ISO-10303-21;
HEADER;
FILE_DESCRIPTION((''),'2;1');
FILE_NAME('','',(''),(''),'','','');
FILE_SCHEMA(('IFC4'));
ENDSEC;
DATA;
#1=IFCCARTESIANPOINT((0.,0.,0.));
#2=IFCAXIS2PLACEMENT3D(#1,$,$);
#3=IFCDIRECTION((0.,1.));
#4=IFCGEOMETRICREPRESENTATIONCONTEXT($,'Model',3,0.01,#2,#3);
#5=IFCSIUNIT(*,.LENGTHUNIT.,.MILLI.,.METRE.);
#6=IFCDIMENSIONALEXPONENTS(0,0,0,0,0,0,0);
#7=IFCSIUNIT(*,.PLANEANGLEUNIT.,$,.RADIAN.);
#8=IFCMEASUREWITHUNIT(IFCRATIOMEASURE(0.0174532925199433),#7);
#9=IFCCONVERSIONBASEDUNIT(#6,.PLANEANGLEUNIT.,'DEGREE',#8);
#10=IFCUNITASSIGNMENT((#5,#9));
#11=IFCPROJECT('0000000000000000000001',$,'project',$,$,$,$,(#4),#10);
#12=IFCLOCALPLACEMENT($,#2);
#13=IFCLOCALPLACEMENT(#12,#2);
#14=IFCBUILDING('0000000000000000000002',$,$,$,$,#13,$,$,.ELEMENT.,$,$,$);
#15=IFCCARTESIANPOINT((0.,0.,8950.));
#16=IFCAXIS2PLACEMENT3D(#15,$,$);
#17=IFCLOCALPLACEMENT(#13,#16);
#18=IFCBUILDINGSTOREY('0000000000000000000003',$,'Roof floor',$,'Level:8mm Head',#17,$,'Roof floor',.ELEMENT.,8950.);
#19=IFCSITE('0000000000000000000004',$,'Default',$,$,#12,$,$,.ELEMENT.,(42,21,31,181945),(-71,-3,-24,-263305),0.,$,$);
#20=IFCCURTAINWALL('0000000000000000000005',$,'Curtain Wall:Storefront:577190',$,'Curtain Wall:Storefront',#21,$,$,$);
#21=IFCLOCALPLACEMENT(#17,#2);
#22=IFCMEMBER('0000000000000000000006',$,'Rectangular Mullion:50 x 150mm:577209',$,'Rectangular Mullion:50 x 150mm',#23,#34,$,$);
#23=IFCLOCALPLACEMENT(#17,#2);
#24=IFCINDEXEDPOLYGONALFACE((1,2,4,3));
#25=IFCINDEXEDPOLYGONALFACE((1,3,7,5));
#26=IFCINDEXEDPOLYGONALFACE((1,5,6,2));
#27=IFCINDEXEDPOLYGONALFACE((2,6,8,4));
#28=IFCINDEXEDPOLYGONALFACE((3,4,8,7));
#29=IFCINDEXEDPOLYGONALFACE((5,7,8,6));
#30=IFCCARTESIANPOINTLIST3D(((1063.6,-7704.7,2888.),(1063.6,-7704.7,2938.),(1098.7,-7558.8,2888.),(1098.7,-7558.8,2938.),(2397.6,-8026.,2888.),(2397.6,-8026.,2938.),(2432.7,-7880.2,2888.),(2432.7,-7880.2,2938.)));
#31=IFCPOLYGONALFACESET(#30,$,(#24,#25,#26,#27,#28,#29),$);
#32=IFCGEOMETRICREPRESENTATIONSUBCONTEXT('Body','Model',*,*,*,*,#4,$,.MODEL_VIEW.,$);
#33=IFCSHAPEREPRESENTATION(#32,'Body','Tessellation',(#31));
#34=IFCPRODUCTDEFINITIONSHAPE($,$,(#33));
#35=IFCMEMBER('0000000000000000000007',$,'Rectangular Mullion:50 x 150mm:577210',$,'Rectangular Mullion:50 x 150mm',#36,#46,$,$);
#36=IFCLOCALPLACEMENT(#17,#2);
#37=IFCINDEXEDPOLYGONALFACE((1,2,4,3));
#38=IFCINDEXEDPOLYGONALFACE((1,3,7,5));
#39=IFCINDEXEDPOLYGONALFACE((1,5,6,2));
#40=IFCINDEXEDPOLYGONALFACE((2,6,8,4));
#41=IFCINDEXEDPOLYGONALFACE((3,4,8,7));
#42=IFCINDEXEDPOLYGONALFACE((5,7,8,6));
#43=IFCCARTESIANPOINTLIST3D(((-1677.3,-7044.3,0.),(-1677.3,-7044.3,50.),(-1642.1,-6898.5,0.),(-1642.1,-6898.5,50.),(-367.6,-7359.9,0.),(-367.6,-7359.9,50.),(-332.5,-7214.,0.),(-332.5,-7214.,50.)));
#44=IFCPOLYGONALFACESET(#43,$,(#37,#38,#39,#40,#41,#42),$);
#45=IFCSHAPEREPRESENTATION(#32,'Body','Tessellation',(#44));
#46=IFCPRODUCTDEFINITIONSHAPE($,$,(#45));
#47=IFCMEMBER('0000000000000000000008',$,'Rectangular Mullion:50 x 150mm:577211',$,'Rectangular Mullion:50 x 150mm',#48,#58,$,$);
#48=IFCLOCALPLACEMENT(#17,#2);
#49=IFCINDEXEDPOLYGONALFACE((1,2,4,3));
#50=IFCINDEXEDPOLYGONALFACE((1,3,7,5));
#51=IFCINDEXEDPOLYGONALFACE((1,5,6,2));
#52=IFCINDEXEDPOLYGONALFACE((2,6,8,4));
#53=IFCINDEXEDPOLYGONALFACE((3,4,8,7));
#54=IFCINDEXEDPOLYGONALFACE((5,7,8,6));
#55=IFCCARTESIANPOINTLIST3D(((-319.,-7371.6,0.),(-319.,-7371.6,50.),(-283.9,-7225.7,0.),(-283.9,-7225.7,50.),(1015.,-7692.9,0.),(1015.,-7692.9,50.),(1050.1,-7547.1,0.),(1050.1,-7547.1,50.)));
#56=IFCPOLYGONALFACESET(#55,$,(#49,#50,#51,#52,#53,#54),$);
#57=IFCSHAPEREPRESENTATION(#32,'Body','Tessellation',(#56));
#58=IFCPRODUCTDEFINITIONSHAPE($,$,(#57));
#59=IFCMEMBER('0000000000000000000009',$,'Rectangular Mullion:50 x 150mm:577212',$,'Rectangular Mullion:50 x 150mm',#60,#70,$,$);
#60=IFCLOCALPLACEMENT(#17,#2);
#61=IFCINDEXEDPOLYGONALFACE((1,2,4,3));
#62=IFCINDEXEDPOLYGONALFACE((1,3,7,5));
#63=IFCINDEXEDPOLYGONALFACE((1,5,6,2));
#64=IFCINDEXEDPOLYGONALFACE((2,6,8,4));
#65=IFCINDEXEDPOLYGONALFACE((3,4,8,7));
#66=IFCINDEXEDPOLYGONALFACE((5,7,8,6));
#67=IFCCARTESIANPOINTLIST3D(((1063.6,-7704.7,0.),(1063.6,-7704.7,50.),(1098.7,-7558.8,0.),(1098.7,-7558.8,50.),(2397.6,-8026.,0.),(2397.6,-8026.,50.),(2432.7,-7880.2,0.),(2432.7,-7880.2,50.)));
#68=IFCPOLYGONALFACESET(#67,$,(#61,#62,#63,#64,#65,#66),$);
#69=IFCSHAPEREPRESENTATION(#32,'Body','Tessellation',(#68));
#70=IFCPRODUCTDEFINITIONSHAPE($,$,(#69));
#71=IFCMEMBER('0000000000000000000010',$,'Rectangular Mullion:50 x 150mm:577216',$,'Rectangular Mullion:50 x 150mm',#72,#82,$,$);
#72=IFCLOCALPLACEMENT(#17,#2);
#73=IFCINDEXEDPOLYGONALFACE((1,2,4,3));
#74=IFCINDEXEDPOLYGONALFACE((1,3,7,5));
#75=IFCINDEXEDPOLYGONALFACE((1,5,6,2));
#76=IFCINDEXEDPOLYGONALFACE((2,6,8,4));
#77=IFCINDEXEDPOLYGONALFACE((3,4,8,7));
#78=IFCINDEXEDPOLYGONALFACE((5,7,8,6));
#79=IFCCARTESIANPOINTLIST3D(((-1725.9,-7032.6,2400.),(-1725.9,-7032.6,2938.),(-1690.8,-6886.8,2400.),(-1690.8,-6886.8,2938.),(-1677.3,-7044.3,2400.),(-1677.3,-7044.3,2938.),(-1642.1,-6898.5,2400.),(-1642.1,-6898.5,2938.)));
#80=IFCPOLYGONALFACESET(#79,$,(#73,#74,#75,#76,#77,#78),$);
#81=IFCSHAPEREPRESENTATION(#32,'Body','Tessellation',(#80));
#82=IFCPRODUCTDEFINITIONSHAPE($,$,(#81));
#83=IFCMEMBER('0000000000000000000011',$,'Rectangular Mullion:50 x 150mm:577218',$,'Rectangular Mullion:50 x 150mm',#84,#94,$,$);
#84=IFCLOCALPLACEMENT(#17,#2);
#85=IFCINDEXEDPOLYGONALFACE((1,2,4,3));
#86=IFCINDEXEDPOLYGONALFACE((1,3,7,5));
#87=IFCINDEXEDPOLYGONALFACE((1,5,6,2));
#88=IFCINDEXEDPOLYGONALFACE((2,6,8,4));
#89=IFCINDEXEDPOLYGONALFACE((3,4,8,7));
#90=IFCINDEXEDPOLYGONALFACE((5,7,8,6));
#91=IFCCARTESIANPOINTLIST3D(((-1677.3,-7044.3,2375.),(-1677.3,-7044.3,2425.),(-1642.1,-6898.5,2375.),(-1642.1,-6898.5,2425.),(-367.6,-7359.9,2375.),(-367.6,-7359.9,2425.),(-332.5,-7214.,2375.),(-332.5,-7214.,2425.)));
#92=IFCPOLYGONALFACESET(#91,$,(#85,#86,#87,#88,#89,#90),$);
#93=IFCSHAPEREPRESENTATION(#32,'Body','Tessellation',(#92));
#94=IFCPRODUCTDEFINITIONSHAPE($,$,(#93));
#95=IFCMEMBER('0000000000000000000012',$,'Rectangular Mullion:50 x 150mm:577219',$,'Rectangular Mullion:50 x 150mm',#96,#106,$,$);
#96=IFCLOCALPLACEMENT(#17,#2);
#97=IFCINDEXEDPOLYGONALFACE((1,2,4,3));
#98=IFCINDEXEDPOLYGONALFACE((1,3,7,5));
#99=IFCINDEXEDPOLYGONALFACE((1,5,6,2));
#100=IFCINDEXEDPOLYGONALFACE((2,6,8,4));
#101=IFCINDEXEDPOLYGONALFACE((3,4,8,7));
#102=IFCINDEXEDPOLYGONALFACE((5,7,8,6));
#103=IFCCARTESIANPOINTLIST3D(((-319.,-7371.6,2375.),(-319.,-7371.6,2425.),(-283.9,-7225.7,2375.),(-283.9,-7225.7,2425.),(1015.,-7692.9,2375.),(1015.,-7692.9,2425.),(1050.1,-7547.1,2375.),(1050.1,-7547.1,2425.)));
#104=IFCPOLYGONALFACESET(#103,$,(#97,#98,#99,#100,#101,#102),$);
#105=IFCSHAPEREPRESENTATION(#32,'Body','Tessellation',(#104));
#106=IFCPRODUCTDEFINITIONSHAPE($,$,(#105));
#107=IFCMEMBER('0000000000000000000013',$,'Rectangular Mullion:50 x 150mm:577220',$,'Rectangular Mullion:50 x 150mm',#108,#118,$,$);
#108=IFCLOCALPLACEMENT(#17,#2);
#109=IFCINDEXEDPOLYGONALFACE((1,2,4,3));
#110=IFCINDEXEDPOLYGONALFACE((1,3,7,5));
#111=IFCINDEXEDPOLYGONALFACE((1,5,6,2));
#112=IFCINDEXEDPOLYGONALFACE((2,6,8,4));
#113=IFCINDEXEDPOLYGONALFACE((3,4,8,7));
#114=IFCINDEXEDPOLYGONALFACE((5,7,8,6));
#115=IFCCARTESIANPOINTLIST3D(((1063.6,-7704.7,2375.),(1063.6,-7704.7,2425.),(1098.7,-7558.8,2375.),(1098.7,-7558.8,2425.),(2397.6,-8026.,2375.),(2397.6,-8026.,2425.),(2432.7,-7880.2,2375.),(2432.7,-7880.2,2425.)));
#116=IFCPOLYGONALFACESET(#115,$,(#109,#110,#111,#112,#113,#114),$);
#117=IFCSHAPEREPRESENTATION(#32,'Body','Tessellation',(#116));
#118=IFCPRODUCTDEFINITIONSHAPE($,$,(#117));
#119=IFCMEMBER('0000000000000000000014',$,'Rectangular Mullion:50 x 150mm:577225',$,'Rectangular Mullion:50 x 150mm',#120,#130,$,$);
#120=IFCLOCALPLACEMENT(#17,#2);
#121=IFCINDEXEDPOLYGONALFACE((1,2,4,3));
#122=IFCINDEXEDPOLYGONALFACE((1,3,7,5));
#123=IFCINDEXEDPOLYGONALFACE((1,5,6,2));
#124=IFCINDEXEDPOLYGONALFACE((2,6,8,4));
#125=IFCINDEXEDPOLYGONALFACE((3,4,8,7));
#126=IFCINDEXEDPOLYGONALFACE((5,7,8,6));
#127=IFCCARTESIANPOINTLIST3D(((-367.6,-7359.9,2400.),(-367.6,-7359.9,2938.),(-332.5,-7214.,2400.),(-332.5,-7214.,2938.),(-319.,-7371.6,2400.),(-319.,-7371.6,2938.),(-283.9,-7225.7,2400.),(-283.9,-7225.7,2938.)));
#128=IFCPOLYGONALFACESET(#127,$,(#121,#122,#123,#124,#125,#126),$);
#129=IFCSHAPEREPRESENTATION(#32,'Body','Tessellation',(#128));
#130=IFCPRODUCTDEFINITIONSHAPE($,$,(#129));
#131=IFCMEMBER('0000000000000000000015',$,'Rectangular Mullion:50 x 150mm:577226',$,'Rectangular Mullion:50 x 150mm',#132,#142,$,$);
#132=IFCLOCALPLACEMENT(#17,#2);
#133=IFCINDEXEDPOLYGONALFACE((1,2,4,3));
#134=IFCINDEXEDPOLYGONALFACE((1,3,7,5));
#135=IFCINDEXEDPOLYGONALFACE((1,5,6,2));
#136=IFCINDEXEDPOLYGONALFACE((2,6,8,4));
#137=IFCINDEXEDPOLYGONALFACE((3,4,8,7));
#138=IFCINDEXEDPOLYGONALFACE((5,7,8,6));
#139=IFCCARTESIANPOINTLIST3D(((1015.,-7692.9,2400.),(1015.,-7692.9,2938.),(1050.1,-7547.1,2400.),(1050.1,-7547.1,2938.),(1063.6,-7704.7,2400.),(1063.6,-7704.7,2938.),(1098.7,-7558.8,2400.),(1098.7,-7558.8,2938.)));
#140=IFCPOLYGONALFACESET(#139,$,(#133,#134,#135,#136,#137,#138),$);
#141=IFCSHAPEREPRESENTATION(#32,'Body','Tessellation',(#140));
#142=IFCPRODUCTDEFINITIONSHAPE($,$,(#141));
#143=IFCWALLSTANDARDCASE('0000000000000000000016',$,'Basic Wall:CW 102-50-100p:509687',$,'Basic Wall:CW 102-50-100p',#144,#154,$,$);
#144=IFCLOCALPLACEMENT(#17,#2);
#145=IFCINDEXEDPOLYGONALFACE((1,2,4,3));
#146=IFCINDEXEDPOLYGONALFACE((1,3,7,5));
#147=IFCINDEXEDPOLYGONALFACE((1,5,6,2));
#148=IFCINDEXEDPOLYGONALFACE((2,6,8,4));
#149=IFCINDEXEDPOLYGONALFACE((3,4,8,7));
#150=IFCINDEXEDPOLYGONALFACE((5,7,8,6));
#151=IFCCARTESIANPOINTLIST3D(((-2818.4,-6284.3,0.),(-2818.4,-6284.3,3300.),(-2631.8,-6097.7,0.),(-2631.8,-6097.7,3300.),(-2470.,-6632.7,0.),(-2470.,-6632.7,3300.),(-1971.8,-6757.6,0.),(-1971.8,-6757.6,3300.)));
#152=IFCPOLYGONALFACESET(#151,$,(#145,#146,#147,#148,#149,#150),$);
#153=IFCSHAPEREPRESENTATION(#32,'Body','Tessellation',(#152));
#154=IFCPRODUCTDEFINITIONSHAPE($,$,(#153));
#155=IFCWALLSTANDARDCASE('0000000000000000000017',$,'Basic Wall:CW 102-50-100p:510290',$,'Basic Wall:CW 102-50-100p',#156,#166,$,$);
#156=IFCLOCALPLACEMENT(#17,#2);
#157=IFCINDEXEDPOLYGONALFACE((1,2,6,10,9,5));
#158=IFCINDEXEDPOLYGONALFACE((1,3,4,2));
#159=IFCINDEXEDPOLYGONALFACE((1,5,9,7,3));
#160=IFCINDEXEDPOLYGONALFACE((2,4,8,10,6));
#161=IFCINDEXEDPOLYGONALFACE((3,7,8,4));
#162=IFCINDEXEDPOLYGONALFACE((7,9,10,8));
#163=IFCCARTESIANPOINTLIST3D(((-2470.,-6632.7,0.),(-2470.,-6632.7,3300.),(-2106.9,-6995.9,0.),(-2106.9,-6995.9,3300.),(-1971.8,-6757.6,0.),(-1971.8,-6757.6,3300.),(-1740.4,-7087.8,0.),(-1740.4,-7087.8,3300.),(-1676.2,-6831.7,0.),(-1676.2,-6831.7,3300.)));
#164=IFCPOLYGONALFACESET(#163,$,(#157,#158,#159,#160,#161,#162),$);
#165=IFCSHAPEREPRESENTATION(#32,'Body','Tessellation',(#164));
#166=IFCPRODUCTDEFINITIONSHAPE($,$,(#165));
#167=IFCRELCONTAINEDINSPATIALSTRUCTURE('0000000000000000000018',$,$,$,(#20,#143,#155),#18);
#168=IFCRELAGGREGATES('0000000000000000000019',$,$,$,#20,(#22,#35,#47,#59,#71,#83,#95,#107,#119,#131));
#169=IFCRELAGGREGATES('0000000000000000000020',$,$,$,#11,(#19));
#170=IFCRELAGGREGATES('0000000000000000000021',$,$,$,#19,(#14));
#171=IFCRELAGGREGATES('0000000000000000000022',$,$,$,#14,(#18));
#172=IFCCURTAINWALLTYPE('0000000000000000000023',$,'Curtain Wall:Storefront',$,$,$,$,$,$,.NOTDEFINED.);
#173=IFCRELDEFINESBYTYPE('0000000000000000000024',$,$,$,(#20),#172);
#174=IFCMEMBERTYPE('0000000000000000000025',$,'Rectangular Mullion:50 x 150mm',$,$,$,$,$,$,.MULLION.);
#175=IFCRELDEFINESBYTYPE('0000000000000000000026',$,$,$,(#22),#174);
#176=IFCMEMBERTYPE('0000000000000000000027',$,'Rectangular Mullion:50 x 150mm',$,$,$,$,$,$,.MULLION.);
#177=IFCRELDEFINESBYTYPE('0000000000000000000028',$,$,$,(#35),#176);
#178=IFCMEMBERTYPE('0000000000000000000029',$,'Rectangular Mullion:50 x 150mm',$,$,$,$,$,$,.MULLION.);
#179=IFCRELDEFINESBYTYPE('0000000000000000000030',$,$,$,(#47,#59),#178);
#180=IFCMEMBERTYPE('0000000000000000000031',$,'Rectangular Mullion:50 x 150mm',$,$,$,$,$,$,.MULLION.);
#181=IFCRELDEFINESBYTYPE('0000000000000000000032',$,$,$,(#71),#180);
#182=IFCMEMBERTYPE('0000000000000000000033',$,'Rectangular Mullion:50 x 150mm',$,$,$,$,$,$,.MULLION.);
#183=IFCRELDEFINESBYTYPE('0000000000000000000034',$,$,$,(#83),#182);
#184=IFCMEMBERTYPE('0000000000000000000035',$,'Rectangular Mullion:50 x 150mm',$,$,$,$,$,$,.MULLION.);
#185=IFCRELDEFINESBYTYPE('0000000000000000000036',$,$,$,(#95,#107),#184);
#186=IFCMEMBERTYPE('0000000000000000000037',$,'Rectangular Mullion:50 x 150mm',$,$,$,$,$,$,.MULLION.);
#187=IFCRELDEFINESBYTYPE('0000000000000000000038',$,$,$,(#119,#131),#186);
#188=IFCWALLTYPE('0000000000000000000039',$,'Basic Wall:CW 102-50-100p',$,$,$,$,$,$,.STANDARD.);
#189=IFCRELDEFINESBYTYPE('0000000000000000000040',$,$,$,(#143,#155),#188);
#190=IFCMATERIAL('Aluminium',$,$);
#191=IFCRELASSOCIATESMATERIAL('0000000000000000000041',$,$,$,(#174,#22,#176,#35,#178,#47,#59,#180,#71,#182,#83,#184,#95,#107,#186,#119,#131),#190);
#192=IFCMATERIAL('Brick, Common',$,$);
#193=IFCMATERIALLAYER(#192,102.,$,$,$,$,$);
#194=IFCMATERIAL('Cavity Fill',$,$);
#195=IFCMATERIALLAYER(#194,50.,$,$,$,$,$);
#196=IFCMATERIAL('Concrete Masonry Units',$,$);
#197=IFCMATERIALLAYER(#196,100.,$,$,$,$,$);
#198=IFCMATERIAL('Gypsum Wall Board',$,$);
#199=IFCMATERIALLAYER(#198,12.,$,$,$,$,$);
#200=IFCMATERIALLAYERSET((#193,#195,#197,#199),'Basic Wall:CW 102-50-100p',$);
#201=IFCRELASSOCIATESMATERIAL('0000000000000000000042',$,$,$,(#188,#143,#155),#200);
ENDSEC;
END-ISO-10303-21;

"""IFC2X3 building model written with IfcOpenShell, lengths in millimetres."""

from ifc_helpers import new_model, entity, si_unit, converted_unit, direction, frame, origin, origin_2d_with_axis, place, context, subcontext, project, spatial, polyline, rectangle, outline, extrude, source, transform, mapped, material, layer, layer_set, layer_usage, type_object, type_shapes, element, aggregate, save


model = new_model("IFC2X3")

# Units and contexts
model_context = context("Model", 3, precision=0.01, world=origin(), true_north=direction((0.0, 1.0)))
body_context = subcontext(model_context, "Body", "Model", "MODEL_VIEW")
ifc_project = project(units=[si_unit("LENGTHUNIT", "METRE", prefix="MILLI"), converted_unit("PLANEANGLEUNIT", "DEGREE", entity("IfcRatioMeasure", 0.0174532925199433), si_unit("PLANEANGLEUNIT", "RADIAN"), dimensions=[0, 0, 0, 0, 0, 0, 0])], contexts=[model_context])

# Site, building, storey
site_placement = place(None, origin())
site = spatial("IfcSite", under=ifc_project, at=site_placement, Name="Default", CompositionType="ELEMENT", RefLatitude=(42, 21, 31, 181945), RefLongitude=(-71, -3, -24, -263305), RefElevation=0.0)
building_placement = place(site_placement, origin())
building = spatial("IfcBuilding", under=site, at=building_placement, CompositionType="ELEMENT")
storey_placement = place(building_placement, frame((0.0, 0.0, 8950.0)))
storey = spatial("IfcBuildingStorey", under=building, at=storey_placement, Name="Roof floor", ObjectType="Level:8mm Head", LongName="Roof floor", CompositionType="ELEMENT", Elevation=8950.0)

# Curtain wall
curtain_wall_type = type_object("IfcCurtainWallType", Name="Curtain Wall:Storefront", PredefinedType="NOTDEFINED")
ifc_material_1 = material(Name="Aluminium")
curtain_wall_1_placement = place(storey_placement, frame((0.0, 0.0, -8950.0)))
curtain_wall_1 = element("IfcCurtainWall", 1, at=curtain_wall_1_placement, inside=storey, type_object=curtain_wall_type, Name="Curtain Wall:Storefront:577190", ObjectType="Curtain Wall:Storefront")

# Members
member_type_1 = type_object("IfcMemberType", Name="Rectangular Mullion:50 x 150mm", PredefinedType="MULLION", material=ifc_material_1)
shared_shape_1 = source(origin(), body_context, "Body", "SweptSolid", [
    extrude(rectangle(XDim=150.0, YDim=50.0, at=origin_2d_with_axis()), frame((-25.0, 0.0, -1372.1), z_axis=(0.0, 0.0, 1.0), x_axis=(0.0, -1.0, 0.0)), (0.0, 0.0, 1.0), 1372.1),
])
type_shapes(member_type_1, [shared_shape_1])
member_1_placement = place(storey_placement, frame((2415.1, -7953.1, 2938.0), z_axis=(0.972184, -0.234217, 0.0), x_axis=(0.0, 0.0, 1.0)))
member_1 = element("IfcMember", 2, at=member_1_placement, type_object=member_type_1, material=ifc_material_1, Name="Rectangular Mullion:50 x 150mm:577209", ObjectType="Rectangular Mullion:50 x 150mm", context=body_context, shape_type="MappedRepresentation", body=[
    mapped(shared_shape_1, transform((0.0, 0.0, 0.0), scale=1.0)),
])
member_type_2 = type_object("IfcMemberType", Name="Rectangular Mullion:50 x 150mm", PredefinedType="MULLION", material=ifc_material_1)
shared_shape_2 = source(origin(), body_context, "Body", "SweptSolid", [
    extrude(rectangle(XDim=150.0, YDim=50.0, at=origin_2d_with_axis()), frame((-25.0, 0.0, -1347.1), z_axis=(0.0, 0.0, 1.0), x_axis=(0.0, -1.0, 0.0)), (0.0, 0.0, 1.0), 1347.1),
])
type_shapes(member_type_2, [shared_shape_2])
member_2_placement = place(storey_placement, frame((-1659.7, -6971.4, 0.0), z_axis=(-0.972184, 0.234217, 0.0), x_axis=(0.0, 0.0, -1.0)))
member_2 = element("IfcMember", 3, at=member_2_placement, type_object=member_type_2, material=ifc_material_1, Name="Rectangular Mullion:50 x 150mm:577210", ObjectType="Rectangular Mullion:50 x 150mm", context=body_context, shape_type="MappedRepresentation", body=[
    mapped(shared_shape_2, transform((0.0, 0.0, 0.0), scale=1.0)),
])
member_type_3 = type_object("IfcMemberType", Name="Rectangular Mullion:50 x 150mm", PredefinedType="MULLION", material=ifc_material_1)
shared_shape_3 = source(origin(), body_context, "Body", "SweptSolid", [
    extrude(rectangle(XDim=150.0, YDim=50.0, at=origin_2d_with_axis()), frame((-25.0, 0.0, -1372.1), z_axis=(0.0, 0.0, 1.0), x_axis=(0.0, -1.0, 0.0)), (0.0, 0.0, 1.0), 1372.1),
])
type_shapes(member_type_3, [shared_shape_3])
member_3_placement = place(storey_placement, frame((-301.4, -7298.7, 0.0), z_axis=(-0.972184, 0.234217, 0.0), x_axis=(0.0, 0.0, -1.0)))
member_3 = element("IfcMember", 4, at=member_3_placement, type_object=member_type_3, material=ifc_material_1, Name="Rectangular Mullion:50 x 150mm:577211", ObjectType="Rectangular Mullion:50 x 150mm", context=body_context, shape_type="MappedRepresentation", body=[
    mapped(shared_shape_3, transform((0.0, 0.0, 0.0), scale=1.0)),
])
member_4_placement = place(storey_placement, frame((1081.1, -7631.7, 0.0), z_axis=(-0.972184, 0.234217, 0.0), x_axis=(0.0, 0.0, -1.0)))
member_4 = element("IfcMember", 5, at=member_4_placement, type_object=member_type_3, material=ifc_material_1, Name="Rectangular Mullion:50 x 150mm:577212", ObjectType="Rectangular Mullion:50 x 150mm", context=body_context, shape_type="MappedRepresentation", body=[
    mapped(shared_shape_3, transform((0.0, 0.0, 0.0), scale=1.0)),
])
member_type_4 = type_object("IfcMemberType", Name="Rectangular Mullion:50 x 150mm", PredefinedType="MULLION", material=ifc_material_1)
shared_shape_4 = source(origin(), body_context, "Body", "SweptSolid", [
    extrude(rectangle(XDim=150.0, YDim=50.0, at=origin_2d_with_axis()), frame((-25.0, 0.0, -538.0), z_axis=(0.0, 0.0, 1.0), x_axis=(0.0, -1.0, 0.0)), (0.0, 0.0, 1.0), 538.0),
])
type_shapes(member_type_4, [shared_shape_4])
member_5_placement = place(storey_placement, frame((-1708.3, -6959.7, 2938.0), z_axis=(0.0, 0.0, 1.0), x_axis=(-0.972184, 0.234217, 0.0)))
member_5 = element("IfcMember", 6, at=member_5_placement, type_object=member_type_4, material=ifc_material_1, Name="Rectangular Mullion:50 x 150mm:577216", ObjectType="Rectangular Mullion:50 x 150mm", context=body_context, shape_type="MappedRepresentation", body=[
    mapped(shared_shape_4, transform((0.0, 0.0, 0.0), scale=1.0)),
])
member_type_5 = type_object("IfcMemberType", Name="Rectangular Mullion:50 x 150mm", PredefinedType="MULLION", material=ifc_material_1)
shared_shape_5 = source(origin(), body_context, "Body", "SweptSolid", [
    extrude(rectangle(XDim=150.0, YDim=50.0, at=origin_2d_with_axis()), frame((0.0, 0.0, -1347.1), z_axis=(0.0, 0.0, 1.0), x_axis=(0.0, -1.0, 0.0)), (0.0, 0.0, 1.0), 1347.1),
])
type_shapes(member_type_5, [shared_shape_5])
member_6_placement = place(storey_placement, frame((-350.0, -7286.9, 2400.0), z_axis=(0.972184, -0.234217, 0.0), x_axis=(0.0, 0.0, 1.0)))
member_6 = element("IfcMember", 7, at=member_6_placement, type_object=member_type_5, material=ifc_material_1, Name="Rectangular Mullion:50 x 150mm:577218", ObjectType="Rectangular Mullion:50 x 150mm", context=body_context, shape_type="MappedRepresentation", body=[
    mapped(shared_shape_5, transform((0.0, 0.0, 0.0), scale=1.0)),
])
member_type_6 = type_object("IfcMemberType", Name="Rectangular Mullion:50 x 150mm", PredefinedType="MULLION", material=ifc_material_1)
shared_shape_6 = source(origin(), body_context, "Body", "SweptSolid", [
    extrude(rectangle(XDim=150.0, YDim=50.0, at=origin_2d_with_axis()), frame((0.0, 0.0, -1372.1), z_axis=(0.0, 0.0, 1.0), x_axis=(0.0, -1.0, 0.0)), (0.0, 0.0, 1.0), 1372.1),
])
type_shapes(member_type_6, [shared_shape_6])
member_7_placement = place(storey_placement, frame((1032.5, -7620.0, 2400.0), z_axis=(0.972184, -0.234217, 0.0), x_axis=(0.0, 0.0, 1.0)))
member_7 = element("IfcMember", 8, at=member_7_placement, type_object=member_type_6, material=ifc_material_1, Name="Rectangular Mullion:50 x 150mm:577219", ObjectType="Rectangular Mullion:50 x 150mm", context=body_context, shape_type="MappedRepresentation", body=[
    mapped(shared_shape_6, transform((0.0, 0.0, 0.0), scale=1.0)),
])
member_8_placement = place(storey_placement, frame((2415.1, -7953.1, 2400.0), z_axis=(0.972184, -0.234217, 0.0), x_axis=(0.0, 0.0, 1.0)))
member_8 = element("IfcMember", 9, at=member_8_placement, type_object=member_type_6, material=ifc_material_1, Name="Rectangular Mullion:50 x 150mm:577220", ObjectType="Rectangular Mullion:50 x 150mm", context=body_context, shape_type="MappedRepresentation", body=[
    mapped(shared_shape_6, transform((0.0, 0.0, 0.0), scale=1.0)),
])
member_type_7 = type_object("IfcMemberType", Name="Rectangular Mullion:50 x 150mm", PredefinedType="MULLION", material=ifc_material_1)
shared_shape_7 = source(origin(), body_context, "Body", "SweptSolid", [
    extrude(rectangle(XDim=150.0, YDim=50.0, at=origin_2d_with_axis()), frame((0.0, 0.0, -538.0), z_axis=(0.0, 0.0, 1.0), x_axis=(0.0, -1.0, 0.0)), (0.0, 0.0, 1.0), 538.0),
])
type_shapes(member_type_7, [shared_shape_7])
member_9_placement = place(storey_placement, frame((-325.7, -7292.8, 2400.0), z_axis=(0.0, 0.0, -1.0), x_axis=(0.972184, -0.234217, 0.0)))
member_9 = element("IfcMember", 10, at=member_9_placement, type_object=member_type_7, material=ifc_material_1, Name="Rectangular Mullion:50 x 150mm:577225", ObjectType="Rectangular Mullion:50 x 150mm", context=body_context, shape_type="MappedRepresentation", body=[
    mapped(shared_shape_7, transform((0.0, 0.0, 0.0), scale=1.0)),
])
member_10_placement = place(storey_placement, frame((1056.8, -7625.9, 2400.0), z_axis=(0.0, 0.0, -1.0), x_axis=(0.972184, -0.234217, 0.0)))
member_10 = element("IfcMember", 11, at=member_10_placement, type_object=member_type_7, material=ifc_material_1, Name="Rectangular Mullion:50 x 150mm:577226", ObjectType="Rectangular Mullion:50 x 150mm", context=body_context, shape_type="MappedRepresentation", body=[
    mapped(shared_shape_7, transform((0.0, 0.0, 0.0), scale=1.0)),
])

aggregate(curtain_wall_1, [member_1, member_2, member_3, member_4, member_5, member_6, member_7, member_8, member_9, member_10])

# Walls
ifc_material_2 = material(Name="Brick, Common")
ifc_layer_1 = layer(ifc_material_2, 102.0)
ifc_material_3 = material(Name="Cavity Fill")
ifc_layer_2 = layer(ifc_material_3, 50.0)
ifc_material_4 = material(Name="Concrete Masonry Units")
ifc_layer_3 = layer(ifc_material_4, 100.0)
ifc_material_5 = material(Name="Gypsum Wall Board")
ifc_layer_4 = layer(ifc_material_5, 12.0)
ifc_layer_set_1 = layer_set([ifc_layer_1, ifc_layer_2, ifc_layer_3, ifc_layer_4], Name="Basic Wall:CW 102-50-100p")
ifc_layer_usage_1 = layer_usage(ifc_layer_set_1, "AXIS2", "NEGATIVE", 132.0)
wall_type = type_object("IfcWallType", Name="Basic Wall:CW 102-50-100p", PredefinedType="STANDARD", material=ifc_layer_set_1)
wall_1_placement = place(storey_placement, frame((-2065.2, -6850.9, 0.0), z_axis=(0.0, 0.0, 1.0), x_axis=(-0.707107, 0.707107, 0.0)))
element("IfcWallStandardCase", 12, at=wall_1_placement, inside=storey, type_object=wall_type, material=ifc_layer_usage_1, Name="Basic Wall:CW 102-50-100p:509687", ObjectType="Basic Wall:CW 102-50-100p", context=body_context, shape_type="SweptSolid", body=[
    extrude(outline(polyline([(933.3, -132.0), (933.3, 132.0), (440.6, 132.0), (0.0, -132.0), (933.3, -132.0)])), origin(), (0.0, 0.0, 1.0), 3300.0),
])
ifc_layer_usage_2 = layer_usage(ifc_layer_set_1, "AXIS2", "NEGATIVE", 132.0)
wall_2_placement = place(storey_placement, frame((-2502.1, -6760.8, 0.0), z_axis=(0.0, 0.0, 1.0), x_axis=(0.970003, -0.243092, 0.0)))
element("IfcWallStandardCase", 13, at=wall_2_placement, inside=storey, type_object=wall_type, material=ifc_layer_usage_2, Name="Basic Wall:CW 102-50-100p:510290", ObjectType="Basic Wall:CW 102-50-100p", context=body_context, shape_type="SweptSolid", body=[
    extrude(outline(polyline([(818.4, -132.0), (818.4, 132.0), (513.6, 132.0), (0.0, 132.0), (440.6, -132.0), (818.4, -132.0)])), origin(), (0.0, 0.0, 1.0), 3300.0),
])

save(model, "model.ifc")
